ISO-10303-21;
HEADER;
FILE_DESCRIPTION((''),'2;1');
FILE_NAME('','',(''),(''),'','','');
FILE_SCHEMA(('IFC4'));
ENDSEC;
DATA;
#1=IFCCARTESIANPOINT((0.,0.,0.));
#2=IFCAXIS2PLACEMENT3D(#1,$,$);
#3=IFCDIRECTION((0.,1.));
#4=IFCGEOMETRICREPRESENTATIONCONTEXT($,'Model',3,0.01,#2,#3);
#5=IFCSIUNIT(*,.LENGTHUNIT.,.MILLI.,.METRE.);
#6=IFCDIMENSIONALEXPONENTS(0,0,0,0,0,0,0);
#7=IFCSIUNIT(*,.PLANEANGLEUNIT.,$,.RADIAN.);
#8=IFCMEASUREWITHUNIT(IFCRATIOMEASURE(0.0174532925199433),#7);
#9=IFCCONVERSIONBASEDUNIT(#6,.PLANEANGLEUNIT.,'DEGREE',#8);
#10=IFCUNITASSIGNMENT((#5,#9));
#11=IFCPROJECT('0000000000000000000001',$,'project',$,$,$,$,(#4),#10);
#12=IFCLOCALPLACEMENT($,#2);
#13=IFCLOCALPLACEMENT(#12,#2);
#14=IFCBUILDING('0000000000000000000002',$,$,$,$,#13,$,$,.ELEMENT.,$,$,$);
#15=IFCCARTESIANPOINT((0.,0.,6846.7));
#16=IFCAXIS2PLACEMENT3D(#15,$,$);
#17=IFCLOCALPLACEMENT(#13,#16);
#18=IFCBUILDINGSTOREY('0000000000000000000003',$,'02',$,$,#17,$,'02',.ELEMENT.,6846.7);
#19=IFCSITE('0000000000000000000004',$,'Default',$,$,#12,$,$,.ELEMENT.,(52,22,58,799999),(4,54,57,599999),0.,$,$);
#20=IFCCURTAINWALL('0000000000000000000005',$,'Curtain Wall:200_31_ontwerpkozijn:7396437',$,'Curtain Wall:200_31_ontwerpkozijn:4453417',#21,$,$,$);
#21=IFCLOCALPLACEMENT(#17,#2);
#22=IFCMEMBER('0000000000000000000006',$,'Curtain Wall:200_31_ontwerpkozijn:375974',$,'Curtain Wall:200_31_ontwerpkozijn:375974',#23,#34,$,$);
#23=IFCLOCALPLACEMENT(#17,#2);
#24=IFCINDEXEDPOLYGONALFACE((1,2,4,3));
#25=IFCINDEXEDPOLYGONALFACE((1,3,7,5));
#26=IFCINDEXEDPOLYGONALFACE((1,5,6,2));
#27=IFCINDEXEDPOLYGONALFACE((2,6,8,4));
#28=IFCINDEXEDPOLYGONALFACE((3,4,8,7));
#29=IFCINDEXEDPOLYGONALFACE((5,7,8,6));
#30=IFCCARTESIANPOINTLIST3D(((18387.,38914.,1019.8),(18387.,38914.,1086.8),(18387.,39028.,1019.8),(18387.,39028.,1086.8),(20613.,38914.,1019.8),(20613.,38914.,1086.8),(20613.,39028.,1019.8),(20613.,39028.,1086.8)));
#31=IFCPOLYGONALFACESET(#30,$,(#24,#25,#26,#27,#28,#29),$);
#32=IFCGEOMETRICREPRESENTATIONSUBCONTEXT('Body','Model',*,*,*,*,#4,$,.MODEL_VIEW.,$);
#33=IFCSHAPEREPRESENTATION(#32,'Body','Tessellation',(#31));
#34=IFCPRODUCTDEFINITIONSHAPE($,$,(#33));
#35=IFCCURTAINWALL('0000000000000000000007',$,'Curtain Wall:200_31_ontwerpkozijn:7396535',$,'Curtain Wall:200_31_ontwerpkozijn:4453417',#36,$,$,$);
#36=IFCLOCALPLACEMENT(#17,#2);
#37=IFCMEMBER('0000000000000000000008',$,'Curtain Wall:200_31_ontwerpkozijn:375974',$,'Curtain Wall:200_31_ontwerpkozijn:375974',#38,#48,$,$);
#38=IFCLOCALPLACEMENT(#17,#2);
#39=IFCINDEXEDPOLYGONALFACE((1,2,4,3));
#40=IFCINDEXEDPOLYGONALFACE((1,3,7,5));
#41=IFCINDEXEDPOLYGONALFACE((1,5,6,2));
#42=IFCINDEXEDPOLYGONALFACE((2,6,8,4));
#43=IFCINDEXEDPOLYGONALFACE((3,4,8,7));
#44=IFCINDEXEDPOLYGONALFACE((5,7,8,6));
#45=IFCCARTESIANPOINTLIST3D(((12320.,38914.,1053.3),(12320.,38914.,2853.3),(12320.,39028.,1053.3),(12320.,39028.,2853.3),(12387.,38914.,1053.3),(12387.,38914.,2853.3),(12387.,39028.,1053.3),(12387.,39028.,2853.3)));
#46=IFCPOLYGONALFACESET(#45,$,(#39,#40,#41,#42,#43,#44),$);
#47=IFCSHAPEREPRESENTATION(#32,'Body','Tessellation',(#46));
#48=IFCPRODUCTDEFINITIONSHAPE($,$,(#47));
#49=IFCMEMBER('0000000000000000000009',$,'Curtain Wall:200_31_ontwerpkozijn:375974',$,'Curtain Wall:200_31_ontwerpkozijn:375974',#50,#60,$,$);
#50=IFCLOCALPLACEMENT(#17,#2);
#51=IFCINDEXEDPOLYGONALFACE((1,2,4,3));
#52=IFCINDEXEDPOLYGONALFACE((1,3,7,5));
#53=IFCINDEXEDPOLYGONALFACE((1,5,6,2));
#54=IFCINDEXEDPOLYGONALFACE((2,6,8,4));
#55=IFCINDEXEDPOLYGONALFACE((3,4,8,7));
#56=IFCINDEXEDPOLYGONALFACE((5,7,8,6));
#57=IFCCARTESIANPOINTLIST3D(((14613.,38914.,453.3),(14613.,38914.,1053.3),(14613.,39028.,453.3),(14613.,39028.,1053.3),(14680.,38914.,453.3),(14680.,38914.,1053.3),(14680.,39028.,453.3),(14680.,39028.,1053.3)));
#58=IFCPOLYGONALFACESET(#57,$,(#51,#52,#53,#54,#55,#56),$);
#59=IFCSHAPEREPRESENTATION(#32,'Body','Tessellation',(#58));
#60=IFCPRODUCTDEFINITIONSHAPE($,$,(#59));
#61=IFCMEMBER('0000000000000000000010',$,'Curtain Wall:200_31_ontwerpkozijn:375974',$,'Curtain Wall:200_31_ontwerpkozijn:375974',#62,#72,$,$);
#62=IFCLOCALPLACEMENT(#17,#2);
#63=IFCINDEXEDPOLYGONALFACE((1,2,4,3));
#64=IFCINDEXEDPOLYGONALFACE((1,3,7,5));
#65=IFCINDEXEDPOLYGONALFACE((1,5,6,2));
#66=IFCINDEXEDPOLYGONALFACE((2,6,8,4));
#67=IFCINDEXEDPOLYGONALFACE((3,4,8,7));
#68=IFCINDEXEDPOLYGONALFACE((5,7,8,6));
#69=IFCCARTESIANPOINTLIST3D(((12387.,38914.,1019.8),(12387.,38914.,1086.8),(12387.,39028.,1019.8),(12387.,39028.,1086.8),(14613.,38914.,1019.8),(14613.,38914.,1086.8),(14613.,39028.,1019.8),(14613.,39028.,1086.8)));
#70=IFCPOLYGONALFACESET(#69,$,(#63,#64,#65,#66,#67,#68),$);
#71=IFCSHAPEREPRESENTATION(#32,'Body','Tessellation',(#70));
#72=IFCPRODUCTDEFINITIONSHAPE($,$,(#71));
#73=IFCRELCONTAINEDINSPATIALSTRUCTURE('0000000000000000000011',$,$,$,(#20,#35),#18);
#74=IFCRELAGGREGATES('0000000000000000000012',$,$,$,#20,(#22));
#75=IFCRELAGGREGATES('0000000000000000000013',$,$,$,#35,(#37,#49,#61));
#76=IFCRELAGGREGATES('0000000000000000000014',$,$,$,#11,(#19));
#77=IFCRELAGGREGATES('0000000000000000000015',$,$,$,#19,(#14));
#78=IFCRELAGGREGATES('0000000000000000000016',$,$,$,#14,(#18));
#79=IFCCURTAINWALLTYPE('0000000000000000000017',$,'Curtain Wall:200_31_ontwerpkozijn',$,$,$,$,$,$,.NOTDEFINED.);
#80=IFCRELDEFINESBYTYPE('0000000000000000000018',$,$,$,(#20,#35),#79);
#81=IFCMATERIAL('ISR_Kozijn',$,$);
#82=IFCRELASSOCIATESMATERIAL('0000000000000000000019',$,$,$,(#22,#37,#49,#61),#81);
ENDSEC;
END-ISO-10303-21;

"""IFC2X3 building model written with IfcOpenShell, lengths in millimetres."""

from ifc_helpers import new_model, entity, si_unit, converted_unit, direction, frame, frame_2d, origin, place, context, subcontext, project, spatial, rectangle, extrude, material, type_object, element, aggregate, save


model = new_model("IFC2X3")

# Units and contexts
model_context = context("Model", 3, precision=0.01, world=origin(), true_north=direction((0.0, 1.0)))
body_context = subcontext(model_context, "Body", "Model", "MODEL_VIEW")
ifc_project = project(units=[si_unit("LENGTHUNIT", "METRE", prefix="MILLI"), converted_unit("PLANEANGLEUNIT", "DEGREE", entity("IfcRatioMeasure", 0.0174532925199433), si_unit("PLANEANGLEUNIT", "RADIAN"), dimensions=[0, 0, 0, 0, 0, 0, 0])], contexts=[model_context])

# Site, building, storey
site_placement = place(None, origin())
site = spatial("IfcSite", under=ifc_project, at=site_placement, Name="Default", CompositionType="ELEMENT", RefLatitude=(52, 22, 58, 799999), RefLongitude=(4, 54, 57, 599999), RefElevation=0.0)
building_placement = place(site_placement, origin())
building = spatial("IfcBuilding", under=site, at=building_placement, CompositionType="ELEMENT")
storey_placement = place(building_placement, frame((0.0, 0.0, 6846.7)))
storey = spatial("IfcBuildingStorey", under=building, at=storey_placement, Name="02", LongName="02", CompositionType="ELEMENT", Elevation=6846.7)

# Curtain walls, members
curtain_wall_type = type_object("IfcCurtainWallType", Name="Curtain Wall:200_31_ontwerpkozijn", PredefinedType="NOTDEFINED")
ifc_material = material(Name="ISR_Kozijn")
curtain_wall_1_placement = place(storey_placement, frame((0.0, 0.0, -6846.7)))
curtain_wall_1 = element("IfcCurtainWall", 1, at=curtain_wall_1_placement, inside=storey, type_object=curtain_wall_type, Name="Curtain Wall:200_31_ontwerpkozijn:7396437", ObjectType="Curtain Wall:200_31_ontwerpkozijn:4453417")
member_1_placement = place(curtain_wall_1_placement, frame((0.0, 0.0, 6846.7)))
member_1 = element("IfcMember", 2, at=member_1_placement, material=ifc_material, Name="Curtain Wall:200_31_ontwerpkozijn:375974", ObjectType="Curtain Wall:200_31_ontwerpkozijn:375974", context=body_context, shape_type="SweptSolid", body=[
    extrude(rectangle(XDim=67.0, YDim=114.0, at=frame_2d((0.0, 0.0), x_axis=(1.0, 0.0))), frame((18387.0, 38971.0, 1053.3), z_axis=(1.0, 0.0, 0.0), x_axis=(0.0, 0.0, -1.0)), (0.0, 0.0, 1.0), 2226.0),
])
aggregate(curtain_wall_1, [member_1])
curtain_wall_2_placement = place(storey_placement, frame((0.0, 0.0, -6846.7)))
curtain_wall_2 = element("IfcCurtainWall", 3, at=curtain_wall_2_placement, inside=storey, type_object=curtain_wall_type, Name="Curtain Wall:200_31_ontwerpkozijn:7396535", ObjectType="Curtain Wall:200_31_ontwerpkozijn:4453417")
member_2_placement = place(curtain_wall_2_placement, frame((0.0, 0.0, 6846.7)))
member_2 = element("IfcMember", 4, at=member_2_placement, material=ifc_material, Name="Curtain Wall:200_31_ontwerpkozijn:375974", ObjectType="Curtain Wall:200_31_ontwerpkozijn:375974", context=body_context, shape_type="SweptSolid", body=[
    extrude(rectangle(XDim=67.0, YDim=114.0, at=frame_2d((0.0, 0.0), x_axis=(1.0, 0.0))), frame((12353.5, 38971.0, 1053.3), z_axis=(0.0, 0.0, 1.0), x_axis=(-1.0, 0.0, 0.0)), (0.0, 0.0, 1.0), 1800.0),
])
member_3_placement = place(curtain_wall_2_placement, frame((0.0, 0.0, 6846.7)))
member_3 = element("IfcMember", 5, at=member_3_placement, material=ifc_material, Name="Curtain Wall:200_31_ontwerpkozijn:375974", ObjectType="Curtain Wall:200_31_ontwerpkozijn:375974", context=body_context, shape_type="SweptSolid", body=[
    extrude(rectangle(XDim=67.0, YDim=114.0, at=frame_2d((0.0, 0.0), x_axis=(1.0, 0.0))), frame((14646.5, 38971.0, 1053.3), z_axis=(0.0, 0.0, -1.0), x_axis=(-1.0, 0.0, 0.0)), (0.0, 0.0, 1.0), 600.0),
])
member_4_placement = place(curtain_wall_2_placement, frame((0.0, 0.0, 6846.7)))
member_4 = element("IfcMember", 6, at=member_4_placement, material=ifc_material, Name="Curtain Wall:200_31_ontwerpkozijn:375974", ObjectType="Curtain Wall:200_31_ontwerpkozijn:375974", context=body_context, shape_type="SweptSolid", body=[
    extrude(rectangle(XDim=67.0, YDim=114.0, at=frame_2d((0.0, 0.0), x_axis=(1.0, 0.0))), frame((12387.0, 38971.0, 1053.3), z_axis=(1.0, 0.0, 0.0), x_axis=(0.0, 0.0, -1.0)), (0.0, 0.0, 1.0), 2226.0),
])
aggregate(curtain_wall_2, [member_2, member_3, member_4])

save(model, "model.ifc")
